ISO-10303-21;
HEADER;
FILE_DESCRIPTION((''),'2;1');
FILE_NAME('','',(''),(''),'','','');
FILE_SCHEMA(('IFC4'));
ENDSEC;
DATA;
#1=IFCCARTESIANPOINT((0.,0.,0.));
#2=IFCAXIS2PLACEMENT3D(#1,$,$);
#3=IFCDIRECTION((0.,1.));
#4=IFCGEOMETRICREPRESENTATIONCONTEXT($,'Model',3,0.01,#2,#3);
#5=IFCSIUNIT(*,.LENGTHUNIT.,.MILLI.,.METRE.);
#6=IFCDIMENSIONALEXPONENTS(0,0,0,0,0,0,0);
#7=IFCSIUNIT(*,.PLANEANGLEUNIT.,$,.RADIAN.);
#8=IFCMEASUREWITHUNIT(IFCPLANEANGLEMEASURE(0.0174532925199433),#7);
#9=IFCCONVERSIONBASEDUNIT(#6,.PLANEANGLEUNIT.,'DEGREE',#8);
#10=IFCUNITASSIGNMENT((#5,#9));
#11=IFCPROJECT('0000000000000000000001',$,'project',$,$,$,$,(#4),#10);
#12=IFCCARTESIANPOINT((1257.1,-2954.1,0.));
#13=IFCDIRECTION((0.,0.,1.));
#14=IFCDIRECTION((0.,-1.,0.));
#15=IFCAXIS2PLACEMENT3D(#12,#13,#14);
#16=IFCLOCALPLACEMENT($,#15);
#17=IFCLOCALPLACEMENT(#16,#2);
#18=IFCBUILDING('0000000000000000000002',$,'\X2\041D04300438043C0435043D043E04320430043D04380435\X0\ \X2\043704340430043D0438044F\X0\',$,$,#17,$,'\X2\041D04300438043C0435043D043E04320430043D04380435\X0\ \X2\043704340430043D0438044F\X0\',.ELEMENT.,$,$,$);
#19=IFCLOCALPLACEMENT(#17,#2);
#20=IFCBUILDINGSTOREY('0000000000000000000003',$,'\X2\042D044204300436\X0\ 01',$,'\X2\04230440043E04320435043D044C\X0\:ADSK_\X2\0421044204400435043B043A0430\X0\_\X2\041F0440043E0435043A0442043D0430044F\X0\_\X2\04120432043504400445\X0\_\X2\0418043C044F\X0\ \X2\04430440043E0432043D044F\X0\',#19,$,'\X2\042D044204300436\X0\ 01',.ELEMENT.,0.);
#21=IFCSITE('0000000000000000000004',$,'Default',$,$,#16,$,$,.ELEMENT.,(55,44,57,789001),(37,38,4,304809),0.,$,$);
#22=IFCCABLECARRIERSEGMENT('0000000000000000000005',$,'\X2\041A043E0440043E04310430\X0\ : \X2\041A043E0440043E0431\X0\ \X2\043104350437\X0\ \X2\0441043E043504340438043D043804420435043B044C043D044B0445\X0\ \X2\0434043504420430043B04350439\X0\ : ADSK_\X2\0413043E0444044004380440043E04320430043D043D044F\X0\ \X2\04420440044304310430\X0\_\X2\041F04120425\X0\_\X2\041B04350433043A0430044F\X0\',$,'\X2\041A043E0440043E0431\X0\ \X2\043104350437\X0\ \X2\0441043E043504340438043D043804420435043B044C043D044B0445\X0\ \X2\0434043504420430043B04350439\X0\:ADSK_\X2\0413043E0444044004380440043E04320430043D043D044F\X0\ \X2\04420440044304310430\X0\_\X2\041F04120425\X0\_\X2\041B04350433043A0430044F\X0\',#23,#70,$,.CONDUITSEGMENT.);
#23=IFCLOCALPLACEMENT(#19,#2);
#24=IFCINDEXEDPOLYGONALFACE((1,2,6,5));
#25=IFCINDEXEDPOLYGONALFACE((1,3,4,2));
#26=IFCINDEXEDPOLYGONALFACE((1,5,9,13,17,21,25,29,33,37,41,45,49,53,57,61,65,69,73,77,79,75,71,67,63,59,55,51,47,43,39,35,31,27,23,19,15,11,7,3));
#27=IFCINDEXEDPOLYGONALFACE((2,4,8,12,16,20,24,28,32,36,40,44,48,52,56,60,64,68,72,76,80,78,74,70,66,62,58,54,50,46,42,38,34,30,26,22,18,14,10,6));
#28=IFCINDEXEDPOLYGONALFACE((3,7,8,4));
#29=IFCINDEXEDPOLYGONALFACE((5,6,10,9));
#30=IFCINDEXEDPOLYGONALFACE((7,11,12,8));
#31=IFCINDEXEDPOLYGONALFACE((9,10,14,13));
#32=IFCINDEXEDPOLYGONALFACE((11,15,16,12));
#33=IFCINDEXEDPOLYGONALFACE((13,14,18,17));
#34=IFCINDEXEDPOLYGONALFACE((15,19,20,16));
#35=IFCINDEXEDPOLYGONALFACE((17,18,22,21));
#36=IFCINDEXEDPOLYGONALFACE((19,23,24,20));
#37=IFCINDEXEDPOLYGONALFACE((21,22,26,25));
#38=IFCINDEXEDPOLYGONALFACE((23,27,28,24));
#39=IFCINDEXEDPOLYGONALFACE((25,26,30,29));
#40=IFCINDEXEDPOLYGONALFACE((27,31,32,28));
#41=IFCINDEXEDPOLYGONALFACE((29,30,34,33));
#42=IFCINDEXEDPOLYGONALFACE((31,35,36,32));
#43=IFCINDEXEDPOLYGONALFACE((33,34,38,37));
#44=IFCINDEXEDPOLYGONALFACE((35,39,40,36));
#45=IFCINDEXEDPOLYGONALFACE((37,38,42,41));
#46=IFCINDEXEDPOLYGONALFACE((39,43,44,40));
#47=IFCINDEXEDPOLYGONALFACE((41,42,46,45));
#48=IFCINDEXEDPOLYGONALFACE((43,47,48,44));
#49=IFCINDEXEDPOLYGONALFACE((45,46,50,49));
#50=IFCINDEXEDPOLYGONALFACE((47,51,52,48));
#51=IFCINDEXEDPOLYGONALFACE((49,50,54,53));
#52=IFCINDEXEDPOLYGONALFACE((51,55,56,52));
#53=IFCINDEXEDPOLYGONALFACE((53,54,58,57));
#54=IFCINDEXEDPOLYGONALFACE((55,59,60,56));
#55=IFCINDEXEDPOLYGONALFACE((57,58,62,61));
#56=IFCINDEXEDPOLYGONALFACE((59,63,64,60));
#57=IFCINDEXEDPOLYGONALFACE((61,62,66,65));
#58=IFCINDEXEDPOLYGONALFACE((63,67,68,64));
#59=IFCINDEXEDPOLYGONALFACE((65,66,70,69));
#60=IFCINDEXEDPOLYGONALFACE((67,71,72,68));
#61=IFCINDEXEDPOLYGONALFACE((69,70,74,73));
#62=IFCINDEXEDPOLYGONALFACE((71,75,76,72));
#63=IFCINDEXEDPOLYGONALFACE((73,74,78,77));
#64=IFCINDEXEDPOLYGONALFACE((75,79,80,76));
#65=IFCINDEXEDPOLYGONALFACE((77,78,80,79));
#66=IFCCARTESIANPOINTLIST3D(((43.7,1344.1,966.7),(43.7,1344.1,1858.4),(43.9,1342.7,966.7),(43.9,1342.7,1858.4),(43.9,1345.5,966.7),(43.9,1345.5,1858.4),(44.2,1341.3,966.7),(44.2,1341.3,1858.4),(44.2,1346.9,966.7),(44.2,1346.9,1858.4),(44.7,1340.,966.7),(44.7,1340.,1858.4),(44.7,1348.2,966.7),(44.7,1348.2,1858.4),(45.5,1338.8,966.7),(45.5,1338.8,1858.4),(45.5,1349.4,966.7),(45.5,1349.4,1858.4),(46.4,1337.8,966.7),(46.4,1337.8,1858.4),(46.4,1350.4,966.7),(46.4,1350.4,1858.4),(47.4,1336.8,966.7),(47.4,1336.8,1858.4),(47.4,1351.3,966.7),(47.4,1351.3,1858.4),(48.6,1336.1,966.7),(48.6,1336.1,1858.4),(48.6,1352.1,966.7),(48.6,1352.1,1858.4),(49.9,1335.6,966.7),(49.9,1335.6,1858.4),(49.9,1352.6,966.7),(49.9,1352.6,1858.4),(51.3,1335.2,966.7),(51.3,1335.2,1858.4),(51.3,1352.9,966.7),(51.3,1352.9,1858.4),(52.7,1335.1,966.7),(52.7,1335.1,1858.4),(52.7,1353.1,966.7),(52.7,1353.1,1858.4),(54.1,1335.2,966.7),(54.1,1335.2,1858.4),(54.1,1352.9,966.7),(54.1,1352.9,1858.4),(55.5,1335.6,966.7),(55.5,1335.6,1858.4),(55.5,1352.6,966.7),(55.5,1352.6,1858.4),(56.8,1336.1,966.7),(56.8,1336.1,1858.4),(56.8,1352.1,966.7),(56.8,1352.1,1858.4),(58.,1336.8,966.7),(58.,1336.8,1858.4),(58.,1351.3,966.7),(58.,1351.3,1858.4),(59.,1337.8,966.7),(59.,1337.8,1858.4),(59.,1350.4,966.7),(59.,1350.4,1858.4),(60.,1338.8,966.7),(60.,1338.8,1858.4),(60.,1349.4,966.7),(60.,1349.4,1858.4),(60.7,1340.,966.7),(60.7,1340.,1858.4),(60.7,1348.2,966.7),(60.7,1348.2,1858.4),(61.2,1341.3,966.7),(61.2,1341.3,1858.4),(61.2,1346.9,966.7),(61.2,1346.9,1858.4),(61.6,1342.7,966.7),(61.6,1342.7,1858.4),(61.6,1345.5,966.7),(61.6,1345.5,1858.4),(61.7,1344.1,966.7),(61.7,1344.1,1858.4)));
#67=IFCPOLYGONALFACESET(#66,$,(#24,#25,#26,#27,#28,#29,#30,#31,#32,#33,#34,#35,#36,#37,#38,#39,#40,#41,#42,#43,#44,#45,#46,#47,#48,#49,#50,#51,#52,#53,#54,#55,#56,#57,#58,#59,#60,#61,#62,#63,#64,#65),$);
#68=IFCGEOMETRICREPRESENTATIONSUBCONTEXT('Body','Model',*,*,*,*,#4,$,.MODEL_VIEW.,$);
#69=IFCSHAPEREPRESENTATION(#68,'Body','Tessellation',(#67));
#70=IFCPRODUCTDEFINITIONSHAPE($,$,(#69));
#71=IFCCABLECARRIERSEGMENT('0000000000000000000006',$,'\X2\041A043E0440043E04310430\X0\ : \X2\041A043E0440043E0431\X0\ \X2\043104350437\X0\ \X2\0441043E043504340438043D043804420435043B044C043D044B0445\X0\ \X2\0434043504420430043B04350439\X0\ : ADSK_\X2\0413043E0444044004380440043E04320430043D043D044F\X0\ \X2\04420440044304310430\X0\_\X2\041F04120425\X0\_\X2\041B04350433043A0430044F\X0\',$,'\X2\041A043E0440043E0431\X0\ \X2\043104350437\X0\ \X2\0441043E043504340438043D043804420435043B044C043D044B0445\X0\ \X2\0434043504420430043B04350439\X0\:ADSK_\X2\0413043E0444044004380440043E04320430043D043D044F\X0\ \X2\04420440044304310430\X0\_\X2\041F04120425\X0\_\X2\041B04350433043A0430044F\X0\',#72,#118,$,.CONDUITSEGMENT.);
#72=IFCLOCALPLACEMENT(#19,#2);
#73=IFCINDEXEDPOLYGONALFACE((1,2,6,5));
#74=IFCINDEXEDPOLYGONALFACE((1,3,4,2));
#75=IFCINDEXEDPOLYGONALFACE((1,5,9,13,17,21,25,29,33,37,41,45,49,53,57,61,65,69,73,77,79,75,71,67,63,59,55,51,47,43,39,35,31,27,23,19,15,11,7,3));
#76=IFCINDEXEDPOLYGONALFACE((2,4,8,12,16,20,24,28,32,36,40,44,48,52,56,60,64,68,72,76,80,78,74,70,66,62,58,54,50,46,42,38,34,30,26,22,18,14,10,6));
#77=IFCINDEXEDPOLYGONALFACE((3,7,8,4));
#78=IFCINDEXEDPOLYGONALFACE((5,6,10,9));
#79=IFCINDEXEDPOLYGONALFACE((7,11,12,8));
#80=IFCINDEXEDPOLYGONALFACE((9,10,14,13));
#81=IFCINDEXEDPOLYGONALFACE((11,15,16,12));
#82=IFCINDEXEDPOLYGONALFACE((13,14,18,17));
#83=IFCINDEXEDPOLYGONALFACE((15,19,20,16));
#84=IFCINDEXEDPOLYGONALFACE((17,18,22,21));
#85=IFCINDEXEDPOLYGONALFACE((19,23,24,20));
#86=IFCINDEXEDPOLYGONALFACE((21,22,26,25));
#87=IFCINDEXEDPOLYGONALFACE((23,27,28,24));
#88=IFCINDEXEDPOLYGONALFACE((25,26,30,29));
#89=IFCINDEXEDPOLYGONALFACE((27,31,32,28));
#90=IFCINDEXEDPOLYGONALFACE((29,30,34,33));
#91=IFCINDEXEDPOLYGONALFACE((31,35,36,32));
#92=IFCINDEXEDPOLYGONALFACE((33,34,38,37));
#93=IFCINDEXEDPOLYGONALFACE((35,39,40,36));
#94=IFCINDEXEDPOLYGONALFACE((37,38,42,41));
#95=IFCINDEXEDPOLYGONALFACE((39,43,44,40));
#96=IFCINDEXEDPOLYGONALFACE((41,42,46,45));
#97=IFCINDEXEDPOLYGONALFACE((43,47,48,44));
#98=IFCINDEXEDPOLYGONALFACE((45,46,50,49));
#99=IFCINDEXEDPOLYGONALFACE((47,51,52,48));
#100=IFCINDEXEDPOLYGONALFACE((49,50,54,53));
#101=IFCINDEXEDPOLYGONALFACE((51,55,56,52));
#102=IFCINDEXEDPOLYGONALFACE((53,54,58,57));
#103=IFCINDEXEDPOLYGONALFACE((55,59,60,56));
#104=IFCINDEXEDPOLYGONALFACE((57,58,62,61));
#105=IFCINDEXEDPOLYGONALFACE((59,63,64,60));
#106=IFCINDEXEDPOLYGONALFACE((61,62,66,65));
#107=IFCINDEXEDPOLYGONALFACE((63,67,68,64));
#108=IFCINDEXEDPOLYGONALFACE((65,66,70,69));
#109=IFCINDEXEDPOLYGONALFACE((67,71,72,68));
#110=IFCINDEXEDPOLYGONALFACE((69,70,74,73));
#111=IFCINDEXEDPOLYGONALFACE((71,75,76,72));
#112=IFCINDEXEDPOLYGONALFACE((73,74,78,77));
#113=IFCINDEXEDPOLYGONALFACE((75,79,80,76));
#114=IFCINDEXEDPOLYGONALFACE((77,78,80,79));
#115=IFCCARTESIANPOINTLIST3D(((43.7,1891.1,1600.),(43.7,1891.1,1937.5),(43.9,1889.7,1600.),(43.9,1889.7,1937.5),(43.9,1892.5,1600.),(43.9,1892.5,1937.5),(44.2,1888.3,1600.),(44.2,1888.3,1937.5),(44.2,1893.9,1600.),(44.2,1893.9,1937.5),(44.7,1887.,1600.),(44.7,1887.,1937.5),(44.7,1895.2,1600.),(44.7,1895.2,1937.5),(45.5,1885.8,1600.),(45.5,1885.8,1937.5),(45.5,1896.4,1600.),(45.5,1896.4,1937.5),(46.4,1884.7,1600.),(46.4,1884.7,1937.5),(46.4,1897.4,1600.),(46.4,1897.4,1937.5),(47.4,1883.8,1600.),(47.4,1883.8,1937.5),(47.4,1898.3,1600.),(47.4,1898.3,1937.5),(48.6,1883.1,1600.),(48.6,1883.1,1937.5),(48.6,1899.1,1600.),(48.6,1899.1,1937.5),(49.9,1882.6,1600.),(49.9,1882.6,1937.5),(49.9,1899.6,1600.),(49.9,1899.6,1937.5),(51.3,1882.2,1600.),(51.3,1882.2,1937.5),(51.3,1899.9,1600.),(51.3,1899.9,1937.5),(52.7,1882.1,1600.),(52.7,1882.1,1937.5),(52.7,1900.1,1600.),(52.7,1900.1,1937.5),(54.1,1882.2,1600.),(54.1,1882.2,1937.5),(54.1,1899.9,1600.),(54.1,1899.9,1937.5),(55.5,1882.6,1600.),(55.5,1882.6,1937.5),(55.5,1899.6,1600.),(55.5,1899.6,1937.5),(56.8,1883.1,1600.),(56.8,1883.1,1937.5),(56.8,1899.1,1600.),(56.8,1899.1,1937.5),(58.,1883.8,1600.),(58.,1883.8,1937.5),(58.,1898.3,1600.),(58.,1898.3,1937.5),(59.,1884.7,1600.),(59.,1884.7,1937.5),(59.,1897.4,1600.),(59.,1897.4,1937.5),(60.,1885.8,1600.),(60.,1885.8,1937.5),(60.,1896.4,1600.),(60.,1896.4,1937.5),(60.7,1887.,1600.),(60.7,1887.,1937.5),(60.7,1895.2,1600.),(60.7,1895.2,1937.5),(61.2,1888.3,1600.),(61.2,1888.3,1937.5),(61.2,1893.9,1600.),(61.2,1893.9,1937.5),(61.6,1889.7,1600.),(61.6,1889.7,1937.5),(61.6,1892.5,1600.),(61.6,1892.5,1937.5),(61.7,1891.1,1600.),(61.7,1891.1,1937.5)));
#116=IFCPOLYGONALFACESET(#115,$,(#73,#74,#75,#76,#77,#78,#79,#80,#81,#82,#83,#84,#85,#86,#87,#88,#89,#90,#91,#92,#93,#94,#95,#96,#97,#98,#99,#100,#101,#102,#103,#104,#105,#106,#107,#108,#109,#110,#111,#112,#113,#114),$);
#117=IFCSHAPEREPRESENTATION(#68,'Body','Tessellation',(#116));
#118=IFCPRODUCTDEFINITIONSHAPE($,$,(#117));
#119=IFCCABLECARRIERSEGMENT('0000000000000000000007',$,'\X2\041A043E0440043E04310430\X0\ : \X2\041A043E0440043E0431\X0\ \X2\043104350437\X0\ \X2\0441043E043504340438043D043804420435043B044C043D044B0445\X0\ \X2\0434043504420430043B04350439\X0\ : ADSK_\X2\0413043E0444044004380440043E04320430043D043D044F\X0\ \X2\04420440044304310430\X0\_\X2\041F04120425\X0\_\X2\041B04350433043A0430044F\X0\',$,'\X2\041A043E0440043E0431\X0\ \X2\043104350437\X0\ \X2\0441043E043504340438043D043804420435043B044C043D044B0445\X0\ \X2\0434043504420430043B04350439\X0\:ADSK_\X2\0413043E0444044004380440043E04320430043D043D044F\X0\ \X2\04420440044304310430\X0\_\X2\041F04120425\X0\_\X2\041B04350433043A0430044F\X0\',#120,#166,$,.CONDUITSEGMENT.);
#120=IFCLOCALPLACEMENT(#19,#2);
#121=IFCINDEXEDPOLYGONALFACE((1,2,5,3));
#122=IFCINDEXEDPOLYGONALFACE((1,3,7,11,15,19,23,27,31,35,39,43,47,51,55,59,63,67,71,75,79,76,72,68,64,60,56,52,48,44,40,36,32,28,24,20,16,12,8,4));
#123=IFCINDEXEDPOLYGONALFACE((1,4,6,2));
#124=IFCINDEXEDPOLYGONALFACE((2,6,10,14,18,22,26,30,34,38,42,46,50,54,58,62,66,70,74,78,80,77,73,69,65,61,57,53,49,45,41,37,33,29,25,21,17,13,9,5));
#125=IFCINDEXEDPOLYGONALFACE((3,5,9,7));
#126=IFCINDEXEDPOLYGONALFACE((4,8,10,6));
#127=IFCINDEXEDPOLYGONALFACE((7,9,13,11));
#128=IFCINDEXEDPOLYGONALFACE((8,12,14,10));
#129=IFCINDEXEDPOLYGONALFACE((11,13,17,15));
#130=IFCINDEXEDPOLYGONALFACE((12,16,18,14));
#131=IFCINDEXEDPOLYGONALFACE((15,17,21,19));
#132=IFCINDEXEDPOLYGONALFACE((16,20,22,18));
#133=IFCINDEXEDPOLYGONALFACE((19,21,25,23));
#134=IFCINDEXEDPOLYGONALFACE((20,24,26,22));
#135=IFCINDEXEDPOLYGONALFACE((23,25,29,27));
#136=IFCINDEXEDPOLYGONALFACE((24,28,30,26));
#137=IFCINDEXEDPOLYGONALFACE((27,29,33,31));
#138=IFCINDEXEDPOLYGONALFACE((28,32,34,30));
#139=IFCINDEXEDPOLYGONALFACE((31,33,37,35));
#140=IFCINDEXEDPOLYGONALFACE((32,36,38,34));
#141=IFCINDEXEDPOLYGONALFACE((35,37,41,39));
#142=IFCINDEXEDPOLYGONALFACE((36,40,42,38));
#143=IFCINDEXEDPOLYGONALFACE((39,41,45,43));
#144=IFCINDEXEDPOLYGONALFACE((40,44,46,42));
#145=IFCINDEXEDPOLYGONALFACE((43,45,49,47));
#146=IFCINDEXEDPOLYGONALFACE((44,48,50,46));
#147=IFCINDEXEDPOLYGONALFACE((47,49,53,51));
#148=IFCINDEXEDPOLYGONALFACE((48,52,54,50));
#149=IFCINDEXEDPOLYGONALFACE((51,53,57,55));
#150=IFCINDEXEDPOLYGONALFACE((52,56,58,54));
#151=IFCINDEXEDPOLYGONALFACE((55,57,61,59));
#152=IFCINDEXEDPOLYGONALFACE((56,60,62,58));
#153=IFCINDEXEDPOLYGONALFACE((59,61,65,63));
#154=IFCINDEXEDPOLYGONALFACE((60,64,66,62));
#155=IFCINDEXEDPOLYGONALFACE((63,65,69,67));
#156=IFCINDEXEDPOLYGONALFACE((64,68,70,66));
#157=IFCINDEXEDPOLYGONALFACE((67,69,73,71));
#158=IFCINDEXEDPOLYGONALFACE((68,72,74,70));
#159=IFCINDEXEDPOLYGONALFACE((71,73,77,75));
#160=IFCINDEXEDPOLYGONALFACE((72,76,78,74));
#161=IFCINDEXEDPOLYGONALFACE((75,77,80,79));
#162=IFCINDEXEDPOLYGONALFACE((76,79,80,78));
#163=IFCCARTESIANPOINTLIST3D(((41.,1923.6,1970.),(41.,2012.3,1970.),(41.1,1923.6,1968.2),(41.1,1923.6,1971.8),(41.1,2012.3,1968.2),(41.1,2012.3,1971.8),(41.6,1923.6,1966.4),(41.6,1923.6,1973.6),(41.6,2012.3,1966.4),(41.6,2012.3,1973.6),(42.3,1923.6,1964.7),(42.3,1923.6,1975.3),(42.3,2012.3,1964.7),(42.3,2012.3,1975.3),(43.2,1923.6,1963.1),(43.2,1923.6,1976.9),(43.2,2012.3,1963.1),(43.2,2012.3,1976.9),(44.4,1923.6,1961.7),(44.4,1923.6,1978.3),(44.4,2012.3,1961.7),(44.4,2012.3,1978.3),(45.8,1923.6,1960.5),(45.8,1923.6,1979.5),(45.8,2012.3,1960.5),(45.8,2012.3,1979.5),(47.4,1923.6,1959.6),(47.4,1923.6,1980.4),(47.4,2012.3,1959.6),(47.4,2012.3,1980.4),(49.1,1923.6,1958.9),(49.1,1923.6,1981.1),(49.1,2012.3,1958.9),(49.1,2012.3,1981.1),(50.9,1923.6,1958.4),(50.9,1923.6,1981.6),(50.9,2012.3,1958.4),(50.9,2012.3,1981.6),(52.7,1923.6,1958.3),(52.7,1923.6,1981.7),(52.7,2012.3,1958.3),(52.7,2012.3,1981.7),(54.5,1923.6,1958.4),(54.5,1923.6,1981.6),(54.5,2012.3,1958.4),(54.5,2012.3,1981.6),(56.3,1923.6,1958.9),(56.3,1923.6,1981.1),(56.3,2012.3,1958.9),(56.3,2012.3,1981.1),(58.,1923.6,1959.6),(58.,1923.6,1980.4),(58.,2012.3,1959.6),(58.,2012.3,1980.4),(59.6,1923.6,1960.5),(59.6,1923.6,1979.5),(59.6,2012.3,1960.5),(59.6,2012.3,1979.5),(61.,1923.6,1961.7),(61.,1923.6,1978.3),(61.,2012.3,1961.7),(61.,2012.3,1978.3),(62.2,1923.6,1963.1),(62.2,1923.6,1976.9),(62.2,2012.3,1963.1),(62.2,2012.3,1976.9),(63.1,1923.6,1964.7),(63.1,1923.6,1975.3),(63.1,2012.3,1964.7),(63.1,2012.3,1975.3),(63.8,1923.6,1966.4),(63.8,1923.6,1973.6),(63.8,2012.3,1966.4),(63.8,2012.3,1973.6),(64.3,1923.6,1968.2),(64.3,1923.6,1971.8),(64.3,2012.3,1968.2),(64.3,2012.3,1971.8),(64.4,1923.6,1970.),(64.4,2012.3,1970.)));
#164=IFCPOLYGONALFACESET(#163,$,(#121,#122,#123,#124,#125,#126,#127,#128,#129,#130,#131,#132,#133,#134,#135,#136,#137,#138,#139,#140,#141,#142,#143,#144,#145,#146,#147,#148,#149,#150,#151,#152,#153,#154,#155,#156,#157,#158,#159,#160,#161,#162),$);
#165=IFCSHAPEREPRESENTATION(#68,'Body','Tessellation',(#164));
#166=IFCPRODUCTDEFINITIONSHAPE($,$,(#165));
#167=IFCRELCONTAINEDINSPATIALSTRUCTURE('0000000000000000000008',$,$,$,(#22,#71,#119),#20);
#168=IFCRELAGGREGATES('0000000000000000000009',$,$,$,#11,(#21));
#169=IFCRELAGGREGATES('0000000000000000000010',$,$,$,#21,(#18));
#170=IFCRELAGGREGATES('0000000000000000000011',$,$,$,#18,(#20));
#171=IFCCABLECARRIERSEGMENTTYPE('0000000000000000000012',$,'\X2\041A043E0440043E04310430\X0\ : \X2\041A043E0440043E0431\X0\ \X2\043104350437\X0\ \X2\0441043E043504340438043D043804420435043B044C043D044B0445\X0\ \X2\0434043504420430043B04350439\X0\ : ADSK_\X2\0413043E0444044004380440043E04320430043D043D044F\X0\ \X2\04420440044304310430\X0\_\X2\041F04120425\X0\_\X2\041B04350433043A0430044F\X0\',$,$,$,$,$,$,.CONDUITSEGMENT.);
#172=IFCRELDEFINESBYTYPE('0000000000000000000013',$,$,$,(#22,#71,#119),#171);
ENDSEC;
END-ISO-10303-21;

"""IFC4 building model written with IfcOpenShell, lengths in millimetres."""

from ifc_helpers import new_model, entity, si_unit, converted_unit, direction, frame, origin, place, context, subcontext, project, spatial, indexed_curve, outline, extrude, type_object, element, save


model = new_model("IFC4")

# Units and contexts
model_context = context("Model", 3, precision=0.01, world=origin(), true_north=direction((0.0, 1.0)))
body_context = subcontext(model_context, "Body", "Model", "MODEL_VIEW")
ifc_project = project(units=[si_unit("LENGTHUNIT", "METRE", prefix="MILLI"), converted_unit("PLANEANGLEUNIT", "DEGREE", entity("IfcPlaneAngleMeasure", 0.0174532925199433), si_unit("PLANEANGLEUNIT", "RADIAN"), dimensions=[0, 0, 0, 0, 0, 0, 0])], contexts=[model_context])

# Site, building, storey
site_placement = place(None, frame((1257.1, -2954.1, 0.0), z_axis=(0.0, 0.0, 1.0), x_axis=(0.0, -1.0, 0.0)))
site = spatial("IfcSite", under=ifc_project, at=site_placement, Name="Default", CompositionType="ELEMENT", RefLatitude=(55, 44, 57, 789001), RefLongitude=(37, 38, 4, 304809), RefElevation=0.0)
building_placement = place(site_placement, origin())
building = spatial("IfcBuilding", under=site, at=building_placement, Name="Наименование здания", LongName="Наименование здания", CompositionType="ELEMENT")
storey_placement = place(building_placement, origin())
storey = spatial("IfcBuildingStorey", under=building, at=storey_placement, Name="Этаж 01", ObjectType="Уровень:ADSK_Стрелка_Проектная_Вверх_Имя уровня", LongName="Этаж 01", CompositionType="ELEMENT", Elevation=0.0)

# Cable carrier segments
cable_carrier_segment_type = type_object("IfcCableCarrierSegmentType", Name="Короба : Короб без соединительных деталей : ADSK_Гофрировання труба_ПВХ_Легкая", PredefinedType="CONDUITSEGMENT")
cable_carrier_segment_1_placement = place(storey_placement, origin())
element("IfcCableCarrierSegment", 1, at=cable_carrier_segment_1_placement, inside=storey, type_object=cable_carrier_segment_type, Name="Короба : Короб без соединительных деталей : ADSK_Гофрировання труба_ПВХ_Легкая", ObjectType="Короб без соединительных деталей:ADSK_Гофрировання труба_ПВХ_Легкая", PredefinedType="CONDUITSEGMENT", context=body_context, shape_type="SweptSolid", body=[
    extrude(outline(indexed_curve([(9.0, 0.0), (8.9, 1.4), (8.5, 2.8), (8.0, 4.1), (7.3, 5.3), (6.3, 6.3), (5.3, 7.3), (4.1, 8.0), (2.8, 8.5), (1.4, 8.9), (0.0, 9.0), (-1.4, 8.9), (-2.8, 8.5), (-4.1, 8.0), (-5.3, 7.3), (-6.3, 6.3), (-7.3, 5.3), (-8.0, 4.1), (-8.5, 2.8), (-8.9, 1.4), (-9.0, 0.0), (-8.9, -1.4), (-8.5, -2.8), (-8.0, -4.1), (-7.3, -5.3), (-6.3, -6.3), (-5.3, -7.3), (-4.1, -8.0), (-2.8, -8.5), (-1.4, -8.9), (0.0, -9.0), (1.4, -8.9), (2.8, -8.5), (4.1, -8.0), (5.3, -7.3), (6.3, -6.3), (7.3, -5.3), (8.0, -4.1), (8.5, -2.8), (8.9, -1.4), (9.0, 0.0)], self_intersect=False)), frame((52.7, 1344.1, 966.7)), (0.0, 0.0, 1.0), 891.8),
])
cable_carrier_segment_2_placement = place(storey_placement, origin())
element("IfcCableCarrierSegment", 2, at=cable_carrier_segment_2_placement, inside=storey, type_object=cable_carrier_segment_type, Name="Короба : Короб без соединительных деталей : ADSK_Гофрировання труба_ПВХ_Легкая", ObjectType="Короб без соединительных деталей:ADSK_Гофрировання труба_ПВХ_Легкая", PredefinedType="CONDUITSEGMENT", context=body_context, shape_type="SweptSolid", body=[
    extrude(outline(indexed_curve([(9.0, 0.0), (8.9, 1.4), (8.5, 2.8), (8.0, 4.1), (7.3, 5.3), (6.3, 6.3), (5.3, 7.3), (4.1, 8.0), (2.8, 8.5), (1.4, 8.9), (0.0, 9.0), (-1.4, 8.9), (-2.8, 8.5), (-4.1, 8.0), (-5.3, 7.3), (-6.3, 6.3), (-7.3, 5.3), (-8.0, 4.1), (-8.5, 2.8), (-8.9, 1.4), (-9.0, 0.0), (-8.9, -1.4), (-8.5, -2.8), (-8.0, -4.1), (-7.3, -5.3), (-6.3, -6.3), (-5.3, -7.3), (-4.1, -8.0), (-2.8, -8.5), (-1.4, -8.9), (0.0, -9.0), (1.4, -8.9), (2.8, -8.5), (4.1, -8.0), (5.3, -7.3), (6.3, -6.3), (7.3, -5.3), (8.0, -4.1), (8.5, -2.8), (8.9, -1.4), (9.0, 0.0)], self_intersect=False)), frame((52.7, 1891.1, 1600.0)), (0.0, 0.0, 1.0), 337.5),
])
cable_carrier_segment_3_placement = place(storey_placement, origin())
element("IfcCableCarrierSegment", 3, at=cable_carrier_segment_3_placement, inside=storey, type_object=cable_carrier_segment_type, Name="Короба : Короб без соединительных деталей : ADSK_Гофрировання труба_ПВХ_Легкая", ObjectType="Короб без соединительных деталей:ADSK_Гофрировання труба_ПВХ_Легкая", PredefinedType="CONDUITSEGMENT", context=body_context, shape_type="SweptSolid", body=[
    extrude(outline(indexed_curve([(11.7, 0.0), (11.6, 1.8), (11.1, 3.6), (10.4, 5.3), (9.5, 6.9), (8.3, 8.3), (6.9, 9.5), (5.3, 10.4), (3.6, 11.1), (1.8, 11.6), (0.0, 11.7), (-1.8, 11.6), (-3.6, 11.1), (-5.3, 10.4), (-6.9, 9.5), (-8.3, 8.3), (-9.5, 6.9), (-10.4, 5.3), (-11.1, 3.6), (-11.6, 1.8), (-11.7, 0.0), (-11.6, -1.8), (-11.1, -3.6), (-10.4, -5.3), (-9.5, -6.9), (-8.3, -8.3), (-6.9, -9.5), (-5.3, -10.4), (-3.6, -11.1), (-1.8, -11.6), (0.0, -11.7), (1.8, -11.6), (3.6, -11.1), (5.3, -10.4), (6.9, -9.5), (8.3, -8.3), (9.5, -6.9), (10.4, -5.3), (11.1, -3.6), (11.6, -1.8), (11.7, 0.0)], self_intersect=False)), frame((52.7, 1923.6, 1970.0), z_axis=(0.0, 1.0, 0.0), x_axis=(-1.0, 0.0, 0.0)), (0.0, 0.0, 1.0), 88.7),
])

save(model, "model.ifc")
